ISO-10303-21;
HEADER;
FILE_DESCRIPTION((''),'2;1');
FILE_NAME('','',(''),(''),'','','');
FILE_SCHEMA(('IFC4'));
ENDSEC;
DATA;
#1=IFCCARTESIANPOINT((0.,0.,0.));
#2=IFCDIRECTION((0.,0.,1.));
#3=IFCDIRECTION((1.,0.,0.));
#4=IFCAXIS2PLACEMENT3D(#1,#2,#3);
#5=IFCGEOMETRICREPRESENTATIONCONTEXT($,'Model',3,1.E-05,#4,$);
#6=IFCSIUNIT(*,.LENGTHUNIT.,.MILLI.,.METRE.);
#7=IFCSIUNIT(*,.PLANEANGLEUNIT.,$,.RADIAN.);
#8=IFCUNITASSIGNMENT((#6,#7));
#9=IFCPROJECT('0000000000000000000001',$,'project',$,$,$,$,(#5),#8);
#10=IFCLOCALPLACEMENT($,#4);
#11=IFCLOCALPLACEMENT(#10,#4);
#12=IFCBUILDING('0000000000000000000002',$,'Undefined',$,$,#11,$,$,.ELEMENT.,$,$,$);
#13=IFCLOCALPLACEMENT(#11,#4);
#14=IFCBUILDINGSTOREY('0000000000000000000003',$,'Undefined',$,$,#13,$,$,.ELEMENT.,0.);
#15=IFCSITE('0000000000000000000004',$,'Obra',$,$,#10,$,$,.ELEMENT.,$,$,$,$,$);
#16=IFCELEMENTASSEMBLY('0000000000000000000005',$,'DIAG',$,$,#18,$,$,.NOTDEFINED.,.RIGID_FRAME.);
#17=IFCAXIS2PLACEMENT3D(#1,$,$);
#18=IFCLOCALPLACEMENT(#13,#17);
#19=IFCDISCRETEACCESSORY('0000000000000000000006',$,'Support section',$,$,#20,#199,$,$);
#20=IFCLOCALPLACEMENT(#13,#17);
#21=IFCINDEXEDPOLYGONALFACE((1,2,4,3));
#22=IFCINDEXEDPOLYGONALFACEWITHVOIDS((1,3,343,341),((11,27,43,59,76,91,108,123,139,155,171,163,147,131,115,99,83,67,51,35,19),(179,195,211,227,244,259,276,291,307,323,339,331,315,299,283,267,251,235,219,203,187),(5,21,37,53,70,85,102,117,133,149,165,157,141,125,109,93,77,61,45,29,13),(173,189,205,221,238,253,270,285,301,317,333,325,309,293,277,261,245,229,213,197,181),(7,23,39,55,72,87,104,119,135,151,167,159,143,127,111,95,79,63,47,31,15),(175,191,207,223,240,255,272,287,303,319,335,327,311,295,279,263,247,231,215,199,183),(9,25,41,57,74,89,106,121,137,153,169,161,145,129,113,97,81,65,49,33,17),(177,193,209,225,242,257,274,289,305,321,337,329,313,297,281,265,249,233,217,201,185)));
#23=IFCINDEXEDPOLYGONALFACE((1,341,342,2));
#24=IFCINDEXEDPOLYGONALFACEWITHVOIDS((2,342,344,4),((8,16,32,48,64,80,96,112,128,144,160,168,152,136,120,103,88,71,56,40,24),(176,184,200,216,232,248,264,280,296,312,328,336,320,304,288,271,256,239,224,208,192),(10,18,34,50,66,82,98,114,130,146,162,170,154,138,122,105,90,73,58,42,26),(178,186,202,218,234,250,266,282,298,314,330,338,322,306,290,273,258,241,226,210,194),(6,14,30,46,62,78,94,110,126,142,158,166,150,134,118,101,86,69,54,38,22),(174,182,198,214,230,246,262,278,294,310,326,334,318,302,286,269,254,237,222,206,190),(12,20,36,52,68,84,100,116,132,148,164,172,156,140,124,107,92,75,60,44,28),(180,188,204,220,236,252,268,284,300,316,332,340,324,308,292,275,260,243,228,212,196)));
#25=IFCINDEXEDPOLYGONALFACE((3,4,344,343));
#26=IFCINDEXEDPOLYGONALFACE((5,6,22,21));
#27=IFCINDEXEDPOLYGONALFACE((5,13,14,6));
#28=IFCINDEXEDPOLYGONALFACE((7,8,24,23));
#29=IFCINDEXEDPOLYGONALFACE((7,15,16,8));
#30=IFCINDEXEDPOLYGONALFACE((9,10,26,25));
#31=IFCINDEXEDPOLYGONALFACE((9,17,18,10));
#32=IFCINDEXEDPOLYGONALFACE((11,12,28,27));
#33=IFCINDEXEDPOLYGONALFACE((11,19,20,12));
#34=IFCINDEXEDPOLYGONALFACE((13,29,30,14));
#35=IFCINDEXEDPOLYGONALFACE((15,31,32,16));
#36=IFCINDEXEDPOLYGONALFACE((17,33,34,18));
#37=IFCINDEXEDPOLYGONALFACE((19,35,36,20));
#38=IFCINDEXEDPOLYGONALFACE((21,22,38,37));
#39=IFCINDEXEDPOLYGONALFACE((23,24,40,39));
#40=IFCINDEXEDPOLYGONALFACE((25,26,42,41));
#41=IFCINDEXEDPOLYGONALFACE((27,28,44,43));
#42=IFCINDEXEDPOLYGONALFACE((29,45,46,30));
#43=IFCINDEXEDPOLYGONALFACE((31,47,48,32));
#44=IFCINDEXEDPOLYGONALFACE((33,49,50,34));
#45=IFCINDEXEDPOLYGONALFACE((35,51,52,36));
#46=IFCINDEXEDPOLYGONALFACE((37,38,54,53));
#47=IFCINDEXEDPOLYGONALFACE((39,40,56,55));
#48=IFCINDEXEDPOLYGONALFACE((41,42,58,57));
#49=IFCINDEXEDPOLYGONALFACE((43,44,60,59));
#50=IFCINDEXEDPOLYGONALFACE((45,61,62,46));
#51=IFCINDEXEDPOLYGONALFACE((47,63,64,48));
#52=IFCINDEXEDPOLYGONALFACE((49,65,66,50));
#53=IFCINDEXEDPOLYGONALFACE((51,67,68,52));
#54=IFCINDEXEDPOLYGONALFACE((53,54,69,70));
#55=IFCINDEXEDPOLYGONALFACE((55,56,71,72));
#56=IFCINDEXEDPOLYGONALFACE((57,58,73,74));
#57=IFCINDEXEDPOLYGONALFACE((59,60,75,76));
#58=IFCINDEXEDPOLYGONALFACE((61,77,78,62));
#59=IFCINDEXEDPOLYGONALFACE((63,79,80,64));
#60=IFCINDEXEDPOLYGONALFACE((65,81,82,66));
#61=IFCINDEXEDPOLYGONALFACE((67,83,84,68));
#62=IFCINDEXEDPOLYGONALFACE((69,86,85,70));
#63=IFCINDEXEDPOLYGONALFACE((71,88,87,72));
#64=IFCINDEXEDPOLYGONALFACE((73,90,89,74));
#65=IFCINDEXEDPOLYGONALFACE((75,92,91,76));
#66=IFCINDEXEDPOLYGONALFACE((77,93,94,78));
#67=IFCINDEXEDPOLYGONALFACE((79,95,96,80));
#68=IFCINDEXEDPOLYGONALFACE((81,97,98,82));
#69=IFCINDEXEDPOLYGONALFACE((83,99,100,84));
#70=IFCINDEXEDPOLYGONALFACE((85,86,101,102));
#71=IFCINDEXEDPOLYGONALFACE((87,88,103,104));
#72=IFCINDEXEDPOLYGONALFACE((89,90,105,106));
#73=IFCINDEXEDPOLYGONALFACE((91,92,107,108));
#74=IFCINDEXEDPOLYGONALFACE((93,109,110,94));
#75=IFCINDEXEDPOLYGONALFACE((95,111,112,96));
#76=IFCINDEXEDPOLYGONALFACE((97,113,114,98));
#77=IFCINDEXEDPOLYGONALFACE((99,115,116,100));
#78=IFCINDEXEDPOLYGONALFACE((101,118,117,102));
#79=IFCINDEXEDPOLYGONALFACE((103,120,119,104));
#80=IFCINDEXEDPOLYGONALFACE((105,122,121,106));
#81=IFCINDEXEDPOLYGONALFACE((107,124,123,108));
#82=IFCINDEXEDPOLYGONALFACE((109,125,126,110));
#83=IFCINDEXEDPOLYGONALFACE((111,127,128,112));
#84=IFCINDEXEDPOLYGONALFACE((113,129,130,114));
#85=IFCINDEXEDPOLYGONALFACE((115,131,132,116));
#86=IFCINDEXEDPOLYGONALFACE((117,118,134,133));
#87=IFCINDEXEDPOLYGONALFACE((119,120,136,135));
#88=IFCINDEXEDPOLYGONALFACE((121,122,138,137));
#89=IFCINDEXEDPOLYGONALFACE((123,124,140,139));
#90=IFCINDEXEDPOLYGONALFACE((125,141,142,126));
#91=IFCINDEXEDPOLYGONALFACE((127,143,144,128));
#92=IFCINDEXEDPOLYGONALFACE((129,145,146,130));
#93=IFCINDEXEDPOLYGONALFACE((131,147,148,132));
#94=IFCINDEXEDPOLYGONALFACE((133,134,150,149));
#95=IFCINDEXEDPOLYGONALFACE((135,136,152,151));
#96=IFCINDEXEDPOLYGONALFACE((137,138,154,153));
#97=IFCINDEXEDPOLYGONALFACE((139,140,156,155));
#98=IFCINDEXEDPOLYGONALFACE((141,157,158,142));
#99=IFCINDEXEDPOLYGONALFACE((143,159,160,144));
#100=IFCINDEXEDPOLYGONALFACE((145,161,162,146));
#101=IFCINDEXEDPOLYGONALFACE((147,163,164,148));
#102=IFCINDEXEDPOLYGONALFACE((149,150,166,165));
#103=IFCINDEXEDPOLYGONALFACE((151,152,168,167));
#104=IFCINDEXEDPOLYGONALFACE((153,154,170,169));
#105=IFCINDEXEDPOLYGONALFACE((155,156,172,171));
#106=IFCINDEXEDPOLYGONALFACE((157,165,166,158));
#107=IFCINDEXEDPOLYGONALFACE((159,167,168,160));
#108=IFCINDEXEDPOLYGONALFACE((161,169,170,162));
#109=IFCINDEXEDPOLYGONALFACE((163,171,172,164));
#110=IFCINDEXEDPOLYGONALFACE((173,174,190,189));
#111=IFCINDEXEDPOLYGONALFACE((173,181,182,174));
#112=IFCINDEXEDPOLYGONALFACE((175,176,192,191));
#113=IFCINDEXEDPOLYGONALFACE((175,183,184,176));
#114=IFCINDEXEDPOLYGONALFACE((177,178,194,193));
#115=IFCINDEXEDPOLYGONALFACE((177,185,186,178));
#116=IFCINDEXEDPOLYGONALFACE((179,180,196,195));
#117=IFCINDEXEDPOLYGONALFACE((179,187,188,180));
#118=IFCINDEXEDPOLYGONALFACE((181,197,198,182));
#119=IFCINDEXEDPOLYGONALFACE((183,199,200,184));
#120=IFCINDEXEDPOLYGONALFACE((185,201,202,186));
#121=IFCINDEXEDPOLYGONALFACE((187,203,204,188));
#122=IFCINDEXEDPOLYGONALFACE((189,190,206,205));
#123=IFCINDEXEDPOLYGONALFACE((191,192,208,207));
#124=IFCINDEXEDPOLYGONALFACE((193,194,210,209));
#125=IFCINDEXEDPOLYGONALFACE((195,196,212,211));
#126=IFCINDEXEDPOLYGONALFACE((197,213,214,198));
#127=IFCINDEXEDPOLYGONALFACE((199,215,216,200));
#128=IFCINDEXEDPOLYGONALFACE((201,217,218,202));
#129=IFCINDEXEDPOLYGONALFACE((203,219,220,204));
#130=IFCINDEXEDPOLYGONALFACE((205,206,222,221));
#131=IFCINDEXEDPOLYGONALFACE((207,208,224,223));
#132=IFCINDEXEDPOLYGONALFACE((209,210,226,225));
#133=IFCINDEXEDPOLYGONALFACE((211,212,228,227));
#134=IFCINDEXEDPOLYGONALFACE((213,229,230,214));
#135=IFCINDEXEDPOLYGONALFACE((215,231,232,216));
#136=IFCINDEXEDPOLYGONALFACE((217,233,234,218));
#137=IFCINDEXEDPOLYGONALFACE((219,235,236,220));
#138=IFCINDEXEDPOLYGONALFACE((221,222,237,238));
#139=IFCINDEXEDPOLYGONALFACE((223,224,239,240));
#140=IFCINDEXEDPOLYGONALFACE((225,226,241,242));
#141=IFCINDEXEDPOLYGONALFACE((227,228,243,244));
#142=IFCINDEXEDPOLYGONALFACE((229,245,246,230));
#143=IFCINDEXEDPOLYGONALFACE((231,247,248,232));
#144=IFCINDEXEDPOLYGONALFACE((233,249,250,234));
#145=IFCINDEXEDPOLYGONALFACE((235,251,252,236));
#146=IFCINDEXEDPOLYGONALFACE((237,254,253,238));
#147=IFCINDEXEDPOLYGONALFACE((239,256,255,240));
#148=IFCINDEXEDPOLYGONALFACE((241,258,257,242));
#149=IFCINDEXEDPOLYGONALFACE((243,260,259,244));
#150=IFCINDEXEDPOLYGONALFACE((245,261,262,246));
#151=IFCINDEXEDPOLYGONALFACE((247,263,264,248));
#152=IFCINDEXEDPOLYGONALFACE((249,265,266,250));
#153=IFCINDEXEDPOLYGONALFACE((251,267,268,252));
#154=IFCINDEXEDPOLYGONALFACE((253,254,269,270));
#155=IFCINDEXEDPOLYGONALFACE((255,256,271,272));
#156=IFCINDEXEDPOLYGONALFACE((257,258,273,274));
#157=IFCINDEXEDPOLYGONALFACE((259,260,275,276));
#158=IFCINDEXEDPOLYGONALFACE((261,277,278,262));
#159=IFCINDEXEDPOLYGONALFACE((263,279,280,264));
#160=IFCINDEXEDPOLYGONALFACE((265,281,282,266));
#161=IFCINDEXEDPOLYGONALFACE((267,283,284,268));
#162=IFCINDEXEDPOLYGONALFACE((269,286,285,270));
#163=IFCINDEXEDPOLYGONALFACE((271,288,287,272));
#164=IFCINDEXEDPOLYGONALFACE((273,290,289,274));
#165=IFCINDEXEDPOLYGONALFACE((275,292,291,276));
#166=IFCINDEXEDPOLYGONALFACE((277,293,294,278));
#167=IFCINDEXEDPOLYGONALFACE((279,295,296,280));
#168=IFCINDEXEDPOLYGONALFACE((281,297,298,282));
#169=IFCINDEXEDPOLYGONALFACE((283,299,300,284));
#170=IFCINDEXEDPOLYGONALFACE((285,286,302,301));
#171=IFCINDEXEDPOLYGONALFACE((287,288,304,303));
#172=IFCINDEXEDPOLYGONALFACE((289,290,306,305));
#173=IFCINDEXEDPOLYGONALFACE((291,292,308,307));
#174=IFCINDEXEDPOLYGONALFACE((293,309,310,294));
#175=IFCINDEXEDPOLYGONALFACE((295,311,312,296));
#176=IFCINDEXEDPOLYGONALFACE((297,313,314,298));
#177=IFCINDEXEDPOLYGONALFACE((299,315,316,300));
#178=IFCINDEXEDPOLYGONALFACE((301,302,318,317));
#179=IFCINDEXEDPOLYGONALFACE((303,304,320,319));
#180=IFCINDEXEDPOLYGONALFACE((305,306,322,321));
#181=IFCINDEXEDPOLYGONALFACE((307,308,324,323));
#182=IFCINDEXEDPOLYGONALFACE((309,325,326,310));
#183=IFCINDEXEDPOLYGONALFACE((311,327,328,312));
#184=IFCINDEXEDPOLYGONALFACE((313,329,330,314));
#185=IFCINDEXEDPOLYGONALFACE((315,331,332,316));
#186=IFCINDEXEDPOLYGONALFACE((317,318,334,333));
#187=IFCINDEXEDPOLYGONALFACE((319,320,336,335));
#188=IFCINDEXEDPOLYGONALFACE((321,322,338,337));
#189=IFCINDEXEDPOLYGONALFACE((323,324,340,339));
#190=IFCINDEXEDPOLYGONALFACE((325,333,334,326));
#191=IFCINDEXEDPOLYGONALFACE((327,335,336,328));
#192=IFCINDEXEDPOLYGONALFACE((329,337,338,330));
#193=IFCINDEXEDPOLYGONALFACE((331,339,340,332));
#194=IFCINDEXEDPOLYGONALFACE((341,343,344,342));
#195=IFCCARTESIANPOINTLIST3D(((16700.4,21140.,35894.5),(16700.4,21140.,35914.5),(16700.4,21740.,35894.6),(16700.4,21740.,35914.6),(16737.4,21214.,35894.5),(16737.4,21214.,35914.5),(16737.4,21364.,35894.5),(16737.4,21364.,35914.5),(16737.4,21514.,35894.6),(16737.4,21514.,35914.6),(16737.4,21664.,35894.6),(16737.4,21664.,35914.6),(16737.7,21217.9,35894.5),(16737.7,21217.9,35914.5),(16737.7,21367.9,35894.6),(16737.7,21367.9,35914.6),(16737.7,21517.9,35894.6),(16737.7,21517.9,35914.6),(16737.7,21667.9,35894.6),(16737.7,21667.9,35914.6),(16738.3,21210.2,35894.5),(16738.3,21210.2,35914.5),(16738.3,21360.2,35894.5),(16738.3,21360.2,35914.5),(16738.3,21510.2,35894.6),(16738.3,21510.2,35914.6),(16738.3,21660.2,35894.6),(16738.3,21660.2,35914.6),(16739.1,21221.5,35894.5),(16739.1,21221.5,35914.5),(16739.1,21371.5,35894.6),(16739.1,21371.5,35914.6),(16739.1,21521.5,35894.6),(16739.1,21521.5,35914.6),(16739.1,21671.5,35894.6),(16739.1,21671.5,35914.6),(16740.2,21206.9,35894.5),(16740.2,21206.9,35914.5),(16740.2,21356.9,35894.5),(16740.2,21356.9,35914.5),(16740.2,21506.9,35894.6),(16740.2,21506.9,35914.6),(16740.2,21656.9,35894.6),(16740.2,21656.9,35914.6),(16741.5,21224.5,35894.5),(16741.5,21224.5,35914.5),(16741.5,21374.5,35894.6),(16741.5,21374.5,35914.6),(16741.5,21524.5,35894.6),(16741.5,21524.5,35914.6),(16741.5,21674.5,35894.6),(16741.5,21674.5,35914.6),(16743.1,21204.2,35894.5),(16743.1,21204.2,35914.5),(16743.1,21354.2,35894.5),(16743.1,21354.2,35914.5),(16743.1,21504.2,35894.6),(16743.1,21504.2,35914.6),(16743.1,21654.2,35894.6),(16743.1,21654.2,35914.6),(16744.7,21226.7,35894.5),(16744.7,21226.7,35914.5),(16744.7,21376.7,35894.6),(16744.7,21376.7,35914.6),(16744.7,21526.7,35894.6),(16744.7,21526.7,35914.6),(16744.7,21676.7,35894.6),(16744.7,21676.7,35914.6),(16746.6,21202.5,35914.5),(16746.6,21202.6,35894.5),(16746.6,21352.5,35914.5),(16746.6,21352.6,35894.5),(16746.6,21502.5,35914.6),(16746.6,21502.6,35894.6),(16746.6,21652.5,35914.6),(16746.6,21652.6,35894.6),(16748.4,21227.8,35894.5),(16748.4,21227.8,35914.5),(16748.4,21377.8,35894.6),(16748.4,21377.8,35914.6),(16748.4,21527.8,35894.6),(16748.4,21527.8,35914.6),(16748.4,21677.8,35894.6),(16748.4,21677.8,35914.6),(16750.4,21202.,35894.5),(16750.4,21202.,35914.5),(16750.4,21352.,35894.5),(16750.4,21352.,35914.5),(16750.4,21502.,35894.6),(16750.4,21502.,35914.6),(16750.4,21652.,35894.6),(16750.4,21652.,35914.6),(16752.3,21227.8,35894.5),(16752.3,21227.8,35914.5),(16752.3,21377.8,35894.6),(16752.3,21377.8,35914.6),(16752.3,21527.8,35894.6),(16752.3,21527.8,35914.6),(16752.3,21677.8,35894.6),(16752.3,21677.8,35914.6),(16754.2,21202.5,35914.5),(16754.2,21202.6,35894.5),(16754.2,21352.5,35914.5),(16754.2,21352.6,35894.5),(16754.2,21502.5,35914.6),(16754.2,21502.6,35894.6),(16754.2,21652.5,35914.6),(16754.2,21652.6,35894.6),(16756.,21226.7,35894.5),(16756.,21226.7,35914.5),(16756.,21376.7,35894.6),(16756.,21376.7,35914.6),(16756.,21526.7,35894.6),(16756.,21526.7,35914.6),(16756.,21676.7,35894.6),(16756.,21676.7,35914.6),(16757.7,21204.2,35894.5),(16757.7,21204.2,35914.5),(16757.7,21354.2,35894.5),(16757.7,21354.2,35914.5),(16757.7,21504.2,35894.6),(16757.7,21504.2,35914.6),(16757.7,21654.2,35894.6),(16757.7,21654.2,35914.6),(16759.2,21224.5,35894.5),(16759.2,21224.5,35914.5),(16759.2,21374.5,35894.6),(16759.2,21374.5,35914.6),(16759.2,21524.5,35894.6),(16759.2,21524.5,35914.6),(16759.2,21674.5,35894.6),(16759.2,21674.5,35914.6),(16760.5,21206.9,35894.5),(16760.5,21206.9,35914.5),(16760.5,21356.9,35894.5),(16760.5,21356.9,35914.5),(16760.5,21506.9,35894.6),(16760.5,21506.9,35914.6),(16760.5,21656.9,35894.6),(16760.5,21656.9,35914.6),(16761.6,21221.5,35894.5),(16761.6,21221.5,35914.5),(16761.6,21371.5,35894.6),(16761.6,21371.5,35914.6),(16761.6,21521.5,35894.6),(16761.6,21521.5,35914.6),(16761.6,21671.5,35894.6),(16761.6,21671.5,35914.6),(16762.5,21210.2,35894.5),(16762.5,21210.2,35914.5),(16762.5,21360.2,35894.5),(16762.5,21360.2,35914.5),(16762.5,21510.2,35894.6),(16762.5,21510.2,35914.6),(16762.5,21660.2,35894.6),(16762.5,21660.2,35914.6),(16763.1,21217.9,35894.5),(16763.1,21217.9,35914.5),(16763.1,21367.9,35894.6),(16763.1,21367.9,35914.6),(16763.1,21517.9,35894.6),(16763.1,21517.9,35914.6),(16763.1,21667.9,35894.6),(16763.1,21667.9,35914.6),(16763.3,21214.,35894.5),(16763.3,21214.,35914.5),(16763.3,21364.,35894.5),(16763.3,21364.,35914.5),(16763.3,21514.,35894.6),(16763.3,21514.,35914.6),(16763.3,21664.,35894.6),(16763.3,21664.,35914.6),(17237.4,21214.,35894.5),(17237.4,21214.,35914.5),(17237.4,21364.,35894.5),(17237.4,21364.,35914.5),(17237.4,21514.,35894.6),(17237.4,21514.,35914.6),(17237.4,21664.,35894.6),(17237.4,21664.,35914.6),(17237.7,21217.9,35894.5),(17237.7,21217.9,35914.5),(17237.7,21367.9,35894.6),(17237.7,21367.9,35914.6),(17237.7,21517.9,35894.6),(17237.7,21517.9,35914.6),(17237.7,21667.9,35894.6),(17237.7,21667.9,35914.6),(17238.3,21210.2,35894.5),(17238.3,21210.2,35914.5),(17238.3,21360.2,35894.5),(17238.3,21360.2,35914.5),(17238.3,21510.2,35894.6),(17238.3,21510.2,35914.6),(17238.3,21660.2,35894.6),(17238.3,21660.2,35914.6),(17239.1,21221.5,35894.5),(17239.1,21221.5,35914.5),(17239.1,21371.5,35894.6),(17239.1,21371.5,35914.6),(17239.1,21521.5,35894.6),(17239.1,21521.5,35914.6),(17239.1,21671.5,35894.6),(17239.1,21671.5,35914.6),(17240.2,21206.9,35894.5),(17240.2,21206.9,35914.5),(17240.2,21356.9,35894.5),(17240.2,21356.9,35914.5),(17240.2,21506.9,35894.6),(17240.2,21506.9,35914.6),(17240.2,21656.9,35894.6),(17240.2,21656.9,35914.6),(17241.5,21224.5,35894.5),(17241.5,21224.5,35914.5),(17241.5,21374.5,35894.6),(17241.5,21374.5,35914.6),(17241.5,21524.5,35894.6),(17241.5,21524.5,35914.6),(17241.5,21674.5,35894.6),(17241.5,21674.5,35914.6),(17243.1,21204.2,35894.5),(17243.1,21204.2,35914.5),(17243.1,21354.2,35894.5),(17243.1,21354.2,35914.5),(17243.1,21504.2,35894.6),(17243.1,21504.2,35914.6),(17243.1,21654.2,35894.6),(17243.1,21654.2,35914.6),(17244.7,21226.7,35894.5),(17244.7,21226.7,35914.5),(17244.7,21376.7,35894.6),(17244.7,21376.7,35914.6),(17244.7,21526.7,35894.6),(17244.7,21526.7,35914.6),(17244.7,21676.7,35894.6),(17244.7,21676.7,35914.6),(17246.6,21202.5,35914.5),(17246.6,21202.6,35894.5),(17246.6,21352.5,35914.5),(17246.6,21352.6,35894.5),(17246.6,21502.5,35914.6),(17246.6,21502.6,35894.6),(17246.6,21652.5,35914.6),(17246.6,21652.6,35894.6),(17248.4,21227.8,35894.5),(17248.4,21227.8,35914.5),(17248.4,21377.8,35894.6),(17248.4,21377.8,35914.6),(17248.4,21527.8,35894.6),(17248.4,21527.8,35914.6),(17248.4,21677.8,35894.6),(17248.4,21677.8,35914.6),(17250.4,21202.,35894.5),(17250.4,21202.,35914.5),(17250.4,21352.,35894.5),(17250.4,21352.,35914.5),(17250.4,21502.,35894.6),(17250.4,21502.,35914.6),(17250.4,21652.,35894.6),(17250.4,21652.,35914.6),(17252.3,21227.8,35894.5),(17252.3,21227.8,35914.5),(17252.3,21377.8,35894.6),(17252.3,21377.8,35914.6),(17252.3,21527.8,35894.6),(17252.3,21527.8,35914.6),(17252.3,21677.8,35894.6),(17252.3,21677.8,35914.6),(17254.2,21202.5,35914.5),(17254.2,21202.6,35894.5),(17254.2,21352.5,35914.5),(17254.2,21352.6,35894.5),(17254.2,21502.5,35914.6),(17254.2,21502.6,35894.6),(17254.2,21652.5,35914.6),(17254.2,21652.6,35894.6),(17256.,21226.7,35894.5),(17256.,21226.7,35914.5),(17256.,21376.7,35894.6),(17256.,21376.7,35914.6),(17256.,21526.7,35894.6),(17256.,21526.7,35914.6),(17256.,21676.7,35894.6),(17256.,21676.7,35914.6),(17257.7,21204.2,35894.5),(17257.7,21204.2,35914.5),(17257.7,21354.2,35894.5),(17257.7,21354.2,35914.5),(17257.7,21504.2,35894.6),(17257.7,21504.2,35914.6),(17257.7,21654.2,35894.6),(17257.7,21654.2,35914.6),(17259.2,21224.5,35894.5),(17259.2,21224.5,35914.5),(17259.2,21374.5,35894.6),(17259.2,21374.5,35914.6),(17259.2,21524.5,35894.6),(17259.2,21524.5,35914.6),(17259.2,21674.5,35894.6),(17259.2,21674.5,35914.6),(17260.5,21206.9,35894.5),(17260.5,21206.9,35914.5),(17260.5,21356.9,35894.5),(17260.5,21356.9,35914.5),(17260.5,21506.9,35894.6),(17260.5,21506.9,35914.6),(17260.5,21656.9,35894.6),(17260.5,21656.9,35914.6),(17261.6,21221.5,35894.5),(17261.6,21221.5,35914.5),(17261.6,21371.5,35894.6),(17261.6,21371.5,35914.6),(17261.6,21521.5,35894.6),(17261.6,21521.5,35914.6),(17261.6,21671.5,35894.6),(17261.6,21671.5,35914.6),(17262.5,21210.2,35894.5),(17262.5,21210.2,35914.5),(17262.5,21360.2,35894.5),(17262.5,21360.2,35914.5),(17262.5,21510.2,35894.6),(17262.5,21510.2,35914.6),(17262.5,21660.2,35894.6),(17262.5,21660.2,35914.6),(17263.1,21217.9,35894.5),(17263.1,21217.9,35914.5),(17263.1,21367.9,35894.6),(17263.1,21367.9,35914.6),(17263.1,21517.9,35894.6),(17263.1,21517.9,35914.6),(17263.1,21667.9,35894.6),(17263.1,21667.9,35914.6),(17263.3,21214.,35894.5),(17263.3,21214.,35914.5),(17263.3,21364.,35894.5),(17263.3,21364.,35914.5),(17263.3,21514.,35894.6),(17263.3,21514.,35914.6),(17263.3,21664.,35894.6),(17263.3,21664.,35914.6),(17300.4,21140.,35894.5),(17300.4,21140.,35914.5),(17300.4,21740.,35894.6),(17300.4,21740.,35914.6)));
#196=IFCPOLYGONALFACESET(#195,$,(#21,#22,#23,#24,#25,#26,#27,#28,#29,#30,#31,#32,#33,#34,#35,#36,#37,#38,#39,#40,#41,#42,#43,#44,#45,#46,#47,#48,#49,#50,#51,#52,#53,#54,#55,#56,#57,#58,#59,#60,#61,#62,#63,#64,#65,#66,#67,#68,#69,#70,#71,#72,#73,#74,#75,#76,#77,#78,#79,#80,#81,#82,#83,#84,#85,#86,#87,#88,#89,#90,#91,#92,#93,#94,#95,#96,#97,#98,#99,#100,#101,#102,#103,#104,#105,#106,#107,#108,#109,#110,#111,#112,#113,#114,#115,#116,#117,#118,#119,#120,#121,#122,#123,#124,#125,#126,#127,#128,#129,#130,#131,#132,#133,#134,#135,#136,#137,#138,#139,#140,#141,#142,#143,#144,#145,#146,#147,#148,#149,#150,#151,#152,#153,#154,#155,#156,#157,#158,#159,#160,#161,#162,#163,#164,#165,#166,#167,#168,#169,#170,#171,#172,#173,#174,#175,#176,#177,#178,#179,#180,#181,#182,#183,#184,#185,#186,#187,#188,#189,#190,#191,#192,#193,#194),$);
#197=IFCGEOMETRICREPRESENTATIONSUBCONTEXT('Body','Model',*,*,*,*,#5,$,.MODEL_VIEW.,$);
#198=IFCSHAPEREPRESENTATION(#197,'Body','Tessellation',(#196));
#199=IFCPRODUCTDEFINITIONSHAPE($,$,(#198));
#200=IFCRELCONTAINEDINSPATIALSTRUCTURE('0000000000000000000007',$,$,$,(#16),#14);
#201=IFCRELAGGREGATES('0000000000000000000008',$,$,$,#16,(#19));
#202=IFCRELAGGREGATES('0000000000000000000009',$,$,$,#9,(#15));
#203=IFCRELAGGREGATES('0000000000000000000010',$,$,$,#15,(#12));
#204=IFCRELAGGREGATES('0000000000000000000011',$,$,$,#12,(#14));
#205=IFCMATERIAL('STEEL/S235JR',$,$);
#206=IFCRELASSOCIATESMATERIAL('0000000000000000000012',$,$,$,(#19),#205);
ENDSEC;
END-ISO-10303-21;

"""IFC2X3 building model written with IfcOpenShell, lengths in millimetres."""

from ifc_helpers import new_model, si_unit, frame, origin_with_axes, origin_2d_with_axis, place, context, subcontext, project, spatial, rectangle, circle, extrude, source, transform, mapped, material, element, aggregate, save


model = new_model("IFC2X3")

# Units and contexts
model_context = context("Model", 3, precision=1e-05, world=origin_with_axes())
body_context = subcontext(model_context, "Body", "Model", "MODEL_VIEW")
ifc_project = project(units=[si_unit("LENGTHUNIT", "METRE", prefix="MILLI"), si_unit("PLANEANGLEUNIT", "RADIAN")], contexts=[model_context])

# Site, building, storey
site_placement = place(None, origin_with_axes())
site = spatial("IfcSite", under=ifc_project, at=site_placement, Name="Obra", CompositionType="ELEMENT")
building_placement = place(site_placement, origin_with_axes())
building = spatial("IfcBuilding", under=site, at=building_placement, Name="Undefined", CompositionType="ELEMENT")
storey_placement = place(building_placement, origin_with_axes())
storey = spatial("IfcBuildingStorey", under=building, at=storey_placement, Name="Undefined", CompositionType="ELEMENT", Elevation=0.0)

# Shared definitions
ifc_material_1 = material(Name="STEEL/S235JR")

# Element assembly
assembly_1_placement = place(storey_placement, origin_with_axes())
assembly_1 = element("IfcElementAssembly", 1, at=assembly_1_placement, inside=storey, Name="DIAG", AssemblyPlace="NOTDEFINED", PredefinedType="RIGID_FRAME")

# Discrete accessory, opening
discrete_accessory_1_placement = place(assembly_1_placement, frame((17000.4, 21140.0, 35904.5), z_axis=(1.0, 0.0, 0.0), x_axis=(0.0, 1.0, 0.000195)))
discrete_accessory_1 = element("IfcDiscreteAccessory", 2, at=discrete_accessory_1_placement, material=ifc_material_1, Name="Support section", context=body_context, shape_type="SweptSolid", body=[
    extrude(rectangle(XDim=20.0, YDim=600.0, at=origin_2d_with_axis()), frame((600.0, 0.0, 0.0), z_axis=(-1.0, 0.0, 0.0), x_axis=(0.0, -1.0, 0.0)), (0.0, 0.0, 1.0), 600.0),
])
shared_shape_1 = source(origin_with_axes(), body_context, "Body", "SweptSolid", [
    extrude(circle(Radius=13.0, at=origin_2d_with_axis()), frame((0.0, -20.1, 0.0), z_axis=(0.0, 1.0, 0.0), x_axis=(1.0, 0.0, 0.0)), (0.0, 0.0, 1.0), 20.2),
])
opening_1_placement = place(assembly_1_placement, frame((17000.4, 21592.5, 35894.6), z_axis=(1.0, 0.0, 0.0), x_axis=(0.0, -1.0, -0.000195)))
element("IfcOpeningElement", 3, at=opening_1_placement, cuts=discrete_accessory_1, ObjectType="Opening", context=body_context, shape_type="MappedRepresentation", body=[
    mapped(shared_shape_1, transform((-72.5, 0.0, -250.0))),
    mapped(shared_shape_1, transform((-72.5, 0.0, 250.0))),
    mapped(shared_shape_1, transform((77.5, 0.0, -250.0))),
    mapped(shared_shape_1, transform((77.5, 0.0, 250.0))),
    mapped(shared_shape_1, transform((227.5, 0.0, -250.0))),
    mapped(shared_shape_1, transform((227.5, 0.0, 250.0))),
    mapped(shared_shape_1, transform((377.5, 0.0, -250.0))),
    mapped(shared_shape_1, transform((377.5, 0.0, 250.0))),
])
aggregate(assembly_1, [discrete_accessory_1])

save(model, "model.ifc")
